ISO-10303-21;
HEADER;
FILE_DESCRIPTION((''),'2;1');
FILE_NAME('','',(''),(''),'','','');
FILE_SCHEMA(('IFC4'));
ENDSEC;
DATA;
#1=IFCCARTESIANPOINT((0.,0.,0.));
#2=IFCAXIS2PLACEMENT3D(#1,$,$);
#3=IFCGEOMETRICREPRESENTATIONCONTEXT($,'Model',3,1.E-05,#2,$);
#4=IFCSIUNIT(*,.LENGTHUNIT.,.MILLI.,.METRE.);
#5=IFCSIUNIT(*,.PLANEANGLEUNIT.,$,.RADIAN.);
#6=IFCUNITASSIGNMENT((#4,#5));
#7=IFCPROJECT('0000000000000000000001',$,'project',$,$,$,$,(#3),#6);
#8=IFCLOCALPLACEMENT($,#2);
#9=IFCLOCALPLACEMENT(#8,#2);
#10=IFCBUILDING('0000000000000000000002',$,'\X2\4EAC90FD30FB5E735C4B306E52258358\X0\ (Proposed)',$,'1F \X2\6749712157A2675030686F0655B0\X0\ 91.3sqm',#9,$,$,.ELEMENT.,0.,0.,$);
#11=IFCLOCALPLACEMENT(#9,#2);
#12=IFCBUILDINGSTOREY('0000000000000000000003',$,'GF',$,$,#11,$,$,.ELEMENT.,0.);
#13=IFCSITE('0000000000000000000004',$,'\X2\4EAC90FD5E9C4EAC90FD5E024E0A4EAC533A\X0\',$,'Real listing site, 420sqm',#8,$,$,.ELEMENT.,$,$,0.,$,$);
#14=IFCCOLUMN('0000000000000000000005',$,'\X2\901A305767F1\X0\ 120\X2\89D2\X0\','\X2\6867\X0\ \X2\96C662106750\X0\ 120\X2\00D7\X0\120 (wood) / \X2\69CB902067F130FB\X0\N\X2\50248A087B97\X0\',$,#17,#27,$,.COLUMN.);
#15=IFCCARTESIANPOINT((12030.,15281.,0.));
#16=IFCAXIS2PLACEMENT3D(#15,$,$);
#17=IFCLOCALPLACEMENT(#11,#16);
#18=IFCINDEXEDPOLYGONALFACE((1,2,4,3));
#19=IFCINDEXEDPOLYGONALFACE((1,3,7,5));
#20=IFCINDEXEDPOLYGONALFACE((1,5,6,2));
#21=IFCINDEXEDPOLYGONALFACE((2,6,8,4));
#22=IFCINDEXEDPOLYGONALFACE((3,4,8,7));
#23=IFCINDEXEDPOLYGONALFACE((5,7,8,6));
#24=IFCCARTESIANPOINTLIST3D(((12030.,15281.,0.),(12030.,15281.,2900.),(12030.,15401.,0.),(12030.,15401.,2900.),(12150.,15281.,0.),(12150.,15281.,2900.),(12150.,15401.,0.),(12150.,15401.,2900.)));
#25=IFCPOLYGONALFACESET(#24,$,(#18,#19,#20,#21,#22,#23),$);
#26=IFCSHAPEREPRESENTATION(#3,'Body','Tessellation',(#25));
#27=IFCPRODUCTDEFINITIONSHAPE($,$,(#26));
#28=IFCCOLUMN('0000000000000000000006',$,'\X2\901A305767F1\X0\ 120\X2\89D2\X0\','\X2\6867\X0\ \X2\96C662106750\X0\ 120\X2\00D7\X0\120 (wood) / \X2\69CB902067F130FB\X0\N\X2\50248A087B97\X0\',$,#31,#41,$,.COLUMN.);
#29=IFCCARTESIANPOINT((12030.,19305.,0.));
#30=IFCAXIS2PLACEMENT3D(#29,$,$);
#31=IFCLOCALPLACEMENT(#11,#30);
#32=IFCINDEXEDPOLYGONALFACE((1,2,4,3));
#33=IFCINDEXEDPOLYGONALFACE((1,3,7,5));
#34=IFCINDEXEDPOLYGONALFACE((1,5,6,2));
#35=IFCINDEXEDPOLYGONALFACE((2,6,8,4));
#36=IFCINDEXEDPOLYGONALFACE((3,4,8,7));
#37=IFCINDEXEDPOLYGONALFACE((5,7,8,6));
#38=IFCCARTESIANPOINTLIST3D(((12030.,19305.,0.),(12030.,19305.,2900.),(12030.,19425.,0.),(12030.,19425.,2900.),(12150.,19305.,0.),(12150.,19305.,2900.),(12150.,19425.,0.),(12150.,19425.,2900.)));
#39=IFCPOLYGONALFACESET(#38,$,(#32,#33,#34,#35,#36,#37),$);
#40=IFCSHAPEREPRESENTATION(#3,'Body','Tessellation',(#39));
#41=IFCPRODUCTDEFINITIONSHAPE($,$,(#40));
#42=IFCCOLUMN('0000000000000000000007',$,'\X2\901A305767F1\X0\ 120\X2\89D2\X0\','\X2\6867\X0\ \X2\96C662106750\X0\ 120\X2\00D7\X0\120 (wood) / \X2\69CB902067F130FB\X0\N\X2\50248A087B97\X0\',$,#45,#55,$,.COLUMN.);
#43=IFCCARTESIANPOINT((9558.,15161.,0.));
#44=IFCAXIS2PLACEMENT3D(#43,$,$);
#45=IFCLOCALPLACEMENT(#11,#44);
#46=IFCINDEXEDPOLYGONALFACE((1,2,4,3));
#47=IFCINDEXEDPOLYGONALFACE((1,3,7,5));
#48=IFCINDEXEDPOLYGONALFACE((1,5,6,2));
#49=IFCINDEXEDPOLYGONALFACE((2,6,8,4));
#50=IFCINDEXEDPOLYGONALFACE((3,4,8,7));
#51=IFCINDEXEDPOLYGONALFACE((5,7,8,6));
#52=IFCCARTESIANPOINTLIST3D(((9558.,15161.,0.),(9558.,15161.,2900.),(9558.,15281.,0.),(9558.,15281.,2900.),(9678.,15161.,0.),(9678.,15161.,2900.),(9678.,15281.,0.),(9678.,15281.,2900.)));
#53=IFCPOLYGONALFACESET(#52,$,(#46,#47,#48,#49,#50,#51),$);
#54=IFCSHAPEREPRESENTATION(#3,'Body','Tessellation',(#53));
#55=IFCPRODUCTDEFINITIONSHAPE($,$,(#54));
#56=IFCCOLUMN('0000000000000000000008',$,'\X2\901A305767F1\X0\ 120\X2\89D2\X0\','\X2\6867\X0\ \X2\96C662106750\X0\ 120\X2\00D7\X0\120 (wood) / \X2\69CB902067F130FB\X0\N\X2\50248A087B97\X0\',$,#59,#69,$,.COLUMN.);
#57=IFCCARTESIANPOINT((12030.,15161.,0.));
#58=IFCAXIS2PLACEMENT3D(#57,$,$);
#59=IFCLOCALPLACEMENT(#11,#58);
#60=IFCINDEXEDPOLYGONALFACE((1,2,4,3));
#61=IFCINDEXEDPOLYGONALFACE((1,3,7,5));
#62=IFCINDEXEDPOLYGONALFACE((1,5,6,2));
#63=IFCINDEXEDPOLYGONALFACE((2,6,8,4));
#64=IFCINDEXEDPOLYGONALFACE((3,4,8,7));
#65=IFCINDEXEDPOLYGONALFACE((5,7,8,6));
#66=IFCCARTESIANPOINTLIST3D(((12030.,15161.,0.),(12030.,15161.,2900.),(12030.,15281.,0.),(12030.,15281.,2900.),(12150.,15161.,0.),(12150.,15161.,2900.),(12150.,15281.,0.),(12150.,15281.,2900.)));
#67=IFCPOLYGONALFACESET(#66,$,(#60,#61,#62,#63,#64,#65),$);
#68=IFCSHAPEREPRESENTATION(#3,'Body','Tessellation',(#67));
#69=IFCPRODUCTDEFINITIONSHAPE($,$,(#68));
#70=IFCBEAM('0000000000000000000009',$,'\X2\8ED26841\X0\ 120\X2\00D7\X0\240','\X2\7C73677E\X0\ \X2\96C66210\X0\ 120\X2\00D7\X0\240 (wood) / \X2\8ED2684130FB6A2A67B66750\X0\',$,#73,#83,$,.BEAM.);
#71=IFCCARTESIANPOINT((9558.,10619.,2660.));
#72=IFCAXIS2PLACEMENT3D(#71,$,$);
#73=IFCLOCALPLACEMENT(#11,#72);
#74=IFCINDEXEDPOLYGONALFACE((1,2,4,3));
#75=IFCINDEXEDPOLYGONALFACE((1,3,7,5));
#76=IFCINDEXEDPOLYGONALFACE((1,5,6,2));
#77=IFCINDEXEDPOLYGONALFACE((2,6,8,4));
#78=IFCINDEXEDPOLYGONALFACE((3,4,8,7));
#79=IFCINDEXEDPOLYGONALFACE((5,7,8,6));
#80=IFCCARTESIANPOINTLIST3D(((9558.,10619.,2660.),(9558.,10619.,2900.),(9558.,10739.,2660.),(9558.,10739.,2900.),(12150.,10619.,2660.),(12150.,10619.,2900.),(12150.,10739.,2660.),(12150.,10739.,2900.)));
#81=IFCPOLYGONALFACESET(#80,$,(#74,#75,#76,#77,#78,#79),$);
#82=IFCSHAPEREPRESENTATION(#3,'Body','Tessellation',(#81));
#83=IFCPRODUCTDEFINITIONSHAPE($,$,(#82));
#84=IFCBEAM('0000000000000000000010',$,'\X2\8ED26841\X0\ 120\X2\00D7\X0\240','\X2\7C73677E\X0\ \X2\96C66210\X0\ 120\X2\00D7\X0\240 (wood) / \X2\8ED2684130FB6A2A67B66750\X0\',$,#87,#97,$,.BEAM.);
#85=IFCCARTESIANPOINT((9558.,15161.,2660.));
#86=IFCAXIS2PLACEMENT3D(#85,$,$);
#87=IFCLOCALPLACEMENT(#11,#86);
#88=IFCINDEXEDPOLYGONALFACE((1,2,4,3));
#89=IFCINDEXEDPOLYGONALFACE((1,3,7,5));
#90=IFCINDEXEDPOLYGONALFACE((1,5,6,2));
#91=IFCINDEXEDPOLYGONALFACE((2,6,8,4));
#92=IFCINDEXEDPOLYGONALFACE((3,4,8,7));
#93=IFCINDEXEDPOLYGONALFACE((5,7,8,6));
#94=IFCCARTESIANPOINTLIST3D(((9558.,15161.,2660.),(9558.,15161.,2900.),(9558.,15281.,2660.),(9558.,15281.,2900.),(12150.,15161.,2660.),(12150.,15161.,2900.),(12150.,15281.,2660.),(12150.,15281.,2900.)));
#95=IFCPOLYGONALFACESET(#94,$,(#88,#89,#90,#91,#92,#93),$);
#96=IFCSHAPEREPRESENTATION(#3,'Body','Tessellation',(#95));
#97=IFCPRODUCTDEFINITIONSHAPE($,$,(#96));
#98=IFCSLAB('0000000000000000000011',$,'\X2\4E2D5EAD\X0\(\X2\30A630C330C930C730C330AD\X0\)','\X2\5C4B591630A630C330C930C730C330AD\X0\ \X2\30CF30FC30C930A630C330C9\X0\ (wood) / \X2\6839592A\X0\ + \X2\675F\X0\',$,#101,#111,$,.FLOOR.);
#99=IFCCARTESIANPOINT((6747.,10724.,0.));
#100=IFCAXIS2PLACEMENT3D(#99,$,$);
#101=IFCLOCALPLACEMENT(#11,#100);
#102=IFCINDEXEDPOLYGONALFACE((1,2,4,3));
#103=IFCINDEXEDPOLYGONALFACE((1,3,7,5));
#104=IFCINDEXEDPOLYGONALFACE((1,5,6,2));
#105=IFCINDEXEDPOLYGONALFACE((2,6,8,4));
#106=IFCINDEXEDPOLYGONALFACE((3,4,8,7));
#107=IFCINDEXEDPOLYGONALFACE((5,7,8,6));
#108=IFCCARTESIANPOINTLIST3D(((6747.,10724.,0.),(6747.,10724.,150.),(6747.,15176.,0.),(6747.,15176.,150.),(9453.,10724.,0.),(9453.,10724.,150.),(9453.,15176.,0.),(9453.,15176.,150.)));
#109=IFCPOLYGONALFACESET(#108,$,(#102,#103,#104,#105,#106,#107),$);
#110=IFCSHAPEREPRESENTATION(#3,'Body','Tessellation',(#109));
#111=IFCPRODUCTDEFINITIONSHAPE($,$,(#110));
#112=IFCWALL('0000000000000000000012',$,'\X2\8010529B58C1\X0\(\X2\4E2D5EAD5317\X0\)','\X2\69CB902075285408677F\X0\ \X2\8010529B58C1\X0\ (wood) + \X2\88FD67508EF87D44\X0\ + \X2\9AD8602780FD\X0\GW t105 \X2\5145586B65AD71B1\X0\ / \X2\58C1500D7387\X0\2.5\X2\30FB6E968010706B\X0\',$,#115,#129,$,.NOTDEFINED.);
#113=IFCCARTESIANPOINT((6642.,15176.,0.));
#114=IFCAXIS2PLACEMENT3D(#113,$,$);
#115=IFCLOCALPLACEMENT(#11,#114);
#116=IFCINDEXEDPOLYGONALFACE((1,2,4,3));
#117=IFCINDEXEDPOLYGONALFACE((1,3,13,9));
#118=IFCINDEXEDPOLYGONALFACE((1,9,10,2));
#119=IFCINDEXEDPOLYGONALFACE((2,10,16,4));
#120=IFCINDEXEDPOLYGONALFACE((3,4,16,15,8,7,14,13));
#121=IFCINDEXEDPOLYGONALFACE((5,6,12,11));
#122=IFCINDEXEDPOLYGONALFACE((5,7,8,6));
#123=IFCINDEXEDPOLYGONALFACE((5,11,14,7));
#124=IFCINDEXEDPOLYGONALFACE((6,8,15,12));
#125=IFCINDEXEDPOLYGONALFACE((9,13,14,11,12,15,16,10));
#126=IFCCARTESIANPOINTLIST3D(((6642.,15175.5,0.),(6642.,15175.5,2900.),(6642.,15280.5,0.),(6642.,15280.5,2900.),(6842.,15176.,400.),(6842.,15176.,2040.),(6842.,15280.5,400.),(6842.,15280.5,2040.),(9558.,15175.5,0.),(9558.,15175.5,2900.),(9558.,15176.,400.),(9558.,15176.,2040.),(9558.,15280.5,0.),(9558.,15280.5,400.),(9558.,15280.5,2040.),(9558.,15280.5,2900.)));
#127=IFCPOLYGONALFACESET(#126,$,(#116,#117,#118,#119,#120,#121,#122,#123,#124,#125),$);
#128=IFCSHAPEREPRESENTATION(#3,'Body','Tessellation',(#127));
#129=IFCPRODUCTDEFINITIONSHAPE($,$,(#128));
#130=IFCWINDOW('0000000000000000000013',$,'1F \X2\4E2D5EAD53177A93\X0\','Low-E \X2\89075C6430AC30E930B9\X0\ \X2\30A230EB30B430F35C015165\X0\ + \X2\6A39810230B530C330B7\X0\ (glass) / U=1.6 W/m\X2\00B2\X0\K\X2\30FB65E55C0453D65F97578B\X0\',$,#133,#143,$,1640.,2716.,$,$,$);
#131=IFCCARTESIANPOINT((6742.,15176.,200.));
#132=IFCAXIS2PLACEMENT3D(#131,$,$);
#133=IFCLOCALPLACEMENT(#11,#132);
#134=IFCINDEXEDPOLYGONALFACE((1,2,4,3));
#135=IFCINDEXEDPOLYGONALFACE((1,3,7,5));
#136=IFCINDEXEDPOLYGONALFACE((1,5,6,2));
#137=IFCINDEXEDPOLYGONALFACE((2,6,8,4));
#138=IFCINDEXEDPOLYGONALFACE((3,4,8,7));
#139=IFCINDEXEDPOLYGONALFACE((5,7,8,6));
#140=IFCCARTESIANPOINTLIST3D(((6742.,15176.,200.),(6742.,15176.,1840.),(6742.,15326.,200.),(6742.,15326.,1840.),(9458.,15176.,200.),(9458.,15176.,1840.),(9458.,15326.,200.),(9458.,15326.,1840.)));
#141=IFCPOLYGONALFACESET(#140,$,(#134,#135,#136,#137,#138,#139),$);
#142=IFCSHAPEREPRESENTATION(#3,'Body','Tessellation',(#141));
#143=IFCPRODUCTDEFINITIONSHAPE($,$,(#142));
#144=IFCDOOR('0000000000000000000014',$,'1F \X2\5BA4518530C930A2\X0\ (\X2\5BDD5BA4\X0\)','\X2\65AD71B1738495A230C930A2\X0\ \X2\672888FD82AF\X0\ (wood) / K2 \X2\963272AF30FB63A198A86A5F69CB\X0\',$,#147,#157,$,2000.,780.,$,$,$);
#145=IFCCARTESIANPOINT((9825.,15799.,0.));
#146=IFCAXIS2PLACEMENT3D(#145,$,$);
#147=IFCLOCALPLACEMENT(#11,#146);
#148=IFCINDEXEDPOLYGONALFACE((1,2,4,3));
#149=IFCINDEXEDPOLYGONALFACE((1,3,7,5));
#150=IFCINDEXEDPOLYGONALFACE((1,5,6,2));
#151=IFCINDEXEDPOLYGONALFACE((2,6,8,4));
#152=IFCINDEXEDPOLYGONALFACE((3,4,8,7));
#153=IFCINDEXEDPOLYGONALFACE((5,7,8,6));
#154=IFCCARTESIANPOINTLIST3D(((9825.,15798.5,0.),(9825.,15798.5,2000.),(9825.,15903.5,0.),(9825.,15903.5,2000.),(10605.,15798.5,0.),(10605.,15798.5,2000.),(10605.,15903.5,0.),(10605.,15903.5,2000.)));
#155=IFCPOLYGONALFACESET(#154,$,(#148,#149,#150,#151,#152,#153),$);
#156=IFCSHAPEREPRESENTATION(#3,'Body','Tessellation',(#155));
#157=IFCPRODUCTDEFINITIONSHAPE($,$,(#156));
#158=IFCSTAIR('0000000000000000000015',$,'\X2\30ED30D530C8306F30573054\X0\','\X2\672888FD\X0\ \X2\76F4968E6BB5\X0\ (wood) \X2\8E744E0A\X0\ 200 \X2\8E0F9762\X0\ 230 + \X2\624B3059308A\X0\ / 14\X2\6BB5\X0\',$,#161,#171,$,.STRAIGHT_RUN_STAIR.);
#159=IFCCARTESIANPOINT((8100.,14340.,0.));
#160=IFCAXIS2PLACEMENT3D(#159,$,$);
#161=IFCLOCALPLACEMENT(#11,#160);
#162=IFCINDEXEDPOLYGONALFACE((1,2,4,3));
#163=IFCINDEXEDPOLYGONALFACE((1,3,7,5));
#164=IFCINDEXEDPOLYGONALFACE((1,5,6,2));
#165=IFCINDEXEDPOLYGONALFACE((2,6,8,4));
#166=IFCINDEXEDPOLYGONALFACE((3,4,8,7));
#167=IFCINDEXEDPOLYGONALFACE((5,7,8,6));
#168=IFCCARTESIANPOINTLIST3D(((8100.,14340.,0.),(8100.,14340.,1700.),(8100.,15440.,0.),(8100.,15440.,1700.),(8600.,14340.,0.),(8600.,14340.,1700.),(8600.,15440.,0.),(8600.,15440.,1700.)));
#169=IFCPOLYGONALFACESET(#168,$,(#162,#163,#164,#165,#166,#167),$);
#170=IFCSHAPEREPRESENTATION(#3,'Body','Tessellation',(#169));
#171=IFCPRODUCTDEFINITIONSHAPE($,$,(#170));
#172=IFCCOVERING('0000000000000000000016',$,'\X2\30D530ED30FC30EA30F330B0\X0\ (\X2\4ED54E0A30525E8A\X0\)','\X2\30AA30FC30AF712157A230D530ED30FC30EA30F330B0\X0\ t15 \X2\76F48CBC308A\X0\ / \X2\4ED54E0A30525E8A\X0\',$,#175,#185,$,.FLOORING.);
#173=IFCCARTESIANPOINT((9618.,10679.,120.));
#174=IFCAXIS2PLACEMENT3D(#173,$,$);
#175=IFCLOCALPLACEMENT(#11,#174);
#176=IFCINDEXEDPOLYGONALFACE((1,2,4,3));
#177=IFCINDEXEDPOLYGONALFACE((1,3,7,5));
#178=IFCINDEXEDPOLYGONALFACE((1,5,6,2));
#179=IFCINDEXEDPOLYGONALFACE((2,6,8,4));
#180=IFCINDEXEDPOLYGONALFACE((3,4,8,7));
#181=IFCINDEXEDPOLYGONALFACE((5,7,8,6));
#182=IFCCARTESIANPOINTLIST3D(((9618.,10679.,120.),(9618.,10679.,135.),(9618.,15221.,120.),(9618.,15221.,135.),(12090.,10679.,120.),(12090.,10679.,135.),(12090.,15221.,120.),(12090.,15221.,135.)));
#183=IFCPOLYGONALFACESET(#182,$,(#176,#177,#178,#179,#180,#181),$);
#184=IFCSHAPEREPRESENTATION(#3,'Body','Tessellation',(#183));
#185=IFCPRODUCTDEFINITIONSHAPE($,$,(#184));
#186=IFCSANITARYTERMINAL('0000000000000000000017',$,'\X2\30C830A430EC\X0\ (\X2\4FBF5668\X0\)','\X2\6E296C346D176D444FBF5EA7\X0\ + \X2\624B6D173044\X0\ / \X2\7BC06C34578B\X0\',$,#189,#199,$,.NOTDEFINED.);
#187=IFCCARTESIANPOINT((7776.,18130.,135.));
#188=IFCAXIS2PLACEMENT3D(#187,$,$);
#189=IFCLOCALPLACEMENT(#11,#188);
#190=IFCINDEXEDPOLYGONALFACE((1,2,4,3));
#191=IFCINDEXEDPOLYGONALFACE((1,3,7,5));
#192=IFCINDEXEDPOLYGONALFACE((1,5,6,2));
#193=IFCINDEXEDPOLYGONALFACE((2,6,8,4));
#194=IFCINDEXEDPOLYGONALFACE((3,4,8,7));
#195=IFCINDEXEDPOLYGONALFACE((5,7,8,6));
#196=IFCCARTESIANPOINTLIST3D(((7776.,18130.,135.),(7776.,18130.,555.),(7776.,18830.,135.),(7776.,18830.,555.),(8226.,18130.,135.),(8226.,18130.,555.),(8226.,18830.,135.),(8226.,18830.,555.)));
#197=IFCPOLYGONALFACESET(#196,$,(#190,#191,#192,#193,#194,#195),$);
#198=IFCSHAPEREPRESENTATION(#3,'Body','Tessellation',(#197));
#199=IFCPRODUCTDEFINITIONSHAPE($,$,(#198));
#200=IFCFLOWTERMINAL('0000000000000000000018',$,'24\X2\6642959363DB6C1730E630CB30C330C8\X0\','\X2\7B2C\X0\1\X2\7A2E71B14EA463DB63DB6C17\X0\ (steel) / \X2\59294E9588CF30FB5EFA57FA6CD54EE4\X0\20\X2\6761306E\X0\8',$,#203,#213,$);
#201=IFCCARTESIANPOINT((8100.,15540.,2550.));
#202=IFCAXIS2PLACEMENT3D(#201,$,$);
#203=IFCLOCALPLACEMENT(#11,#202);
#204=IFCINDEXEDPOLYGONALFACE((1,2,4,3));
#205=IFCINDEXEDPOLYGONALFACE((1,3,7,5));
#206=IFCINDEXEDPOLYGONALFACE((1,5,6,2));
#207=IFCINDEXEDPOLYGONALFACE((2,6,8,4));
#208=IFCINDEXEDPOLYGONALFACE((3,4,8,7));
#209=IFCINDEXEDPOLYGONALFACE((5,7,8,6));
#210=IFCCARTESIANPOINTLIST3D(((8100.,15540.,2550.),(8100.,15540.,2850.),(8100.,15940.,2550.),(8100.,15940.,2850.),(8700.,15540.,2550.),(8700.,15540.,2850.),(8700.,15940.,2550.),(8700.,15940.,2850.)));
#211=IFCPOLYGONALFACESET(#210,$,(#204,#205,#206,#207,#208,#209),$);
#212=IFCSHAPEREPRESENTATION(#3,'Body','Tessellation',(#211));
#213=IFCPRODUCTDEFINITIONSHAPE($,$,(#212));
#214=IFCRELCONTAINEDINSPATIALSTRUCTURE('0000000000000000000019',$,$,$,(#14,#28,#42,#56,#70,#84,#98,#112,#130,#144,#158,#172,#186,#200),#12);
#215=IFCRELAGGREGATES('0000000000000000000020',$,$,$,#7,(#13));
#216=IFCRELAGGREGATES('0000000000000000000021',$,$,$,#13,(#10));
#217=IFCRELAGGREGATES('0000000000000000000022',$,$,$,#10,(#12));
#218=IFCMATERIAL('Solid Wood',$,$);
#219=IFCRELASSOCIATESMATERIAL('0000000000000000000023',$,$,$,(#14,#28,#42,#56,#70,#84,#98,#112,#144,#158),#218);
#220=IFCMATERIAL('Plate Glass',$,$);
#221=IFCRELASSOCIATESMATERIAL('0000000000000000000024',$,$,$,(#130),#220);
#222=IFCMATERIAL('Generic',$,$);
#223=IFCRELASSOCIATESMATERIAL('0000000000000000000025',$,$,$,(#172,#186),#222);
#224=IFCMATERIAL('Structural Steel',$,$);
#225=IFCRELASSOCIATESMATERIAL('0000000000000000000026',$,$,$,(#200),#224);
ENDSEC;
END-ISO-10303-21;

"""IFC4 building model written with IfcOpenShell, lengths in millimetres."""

from ifc_helpers import new_model, si_unit, frame, frame_2d, origin, place, context, project, spatial, rectangle, extrude, material, element, fill, save


model = new_model("IFC4")

# Units and contexts
model_context = context("Model", 3, precision=1e-05, world=origin())
ifc_project = project(units=[si_unit("LENGTHUNIT", "METRE", prefix="MILLI"), si_unit("PLANEANGLEUNIT", "RADIAN")], contexts=[model_context])

# Site, building, storey
site_placement = place(None, origin())
site = spatial("IfcSite", under=ifc_project, at=site_placement, Name="京都府京都市上京区", ObjectType="Real listing site, 420sqm", CompositionType="ELEMENT", RefElevation=0.0)
building_placement = place(site_placement, origin())
building = spatial("IfcBuilding", under=site, at=building_placement, Name="京都・平屋の別荘 (Proposed)", ObjectType="1F 杉無垢材と漆喰 91.3sqm", CompositionType="ELEMENT", ElevationOfRefHeight=0.0, ElevationOfTerrain=0.0)
storey_placement = place(building_placement, origin())
storey = spatial("IfcBuildingStorey", under=building, at=storey_placement, Name="GF", CompositionType="ELEMENT", Elevation=0.0)

# Columns
ifc_material_1 = material(Name="Solid Wood")
column_1_placement = place(storey_placement, frame((12030.0, 15281.0, 0.0)))
element("IfcColumn", 1, at=column_1_placement, inside=storey, material=ifc_material_1, Name="通し柱 120角", Description="桧 集成材 120×120 (wood) / 構造柱・N値計算", PredefinedType="COLUMN", context=model_context, shape_type="SweptSolid", body=[
    extrude(rectangle(XDim=120.0, YDim=120.0, at=frame_2d((60.0, 60.0))), frame((12030.0, 15281.0, 0.0)), (0.0, 0.0, 1.0), 2900.0),
])
column_2_placement = place(storey_placement, frame((12030.0, 19305.0, 0.0)))
element("IfcColumn", 2, at=column_2_placement, inside=storey, material=ifc_material_1, Name="通し柱 120角", Description="桧 集成材 120×120 (wood) / 構造柱・N値計算", PredefinedType="COLUMN", context=model_context, shape_type="SweptSolid", body=[
    extrude(rectangle(XDim=120.0, YDim=120.0, at=frame_2d((60.0, 60.0))), frame((12030.0, 19305.0, 0.0)), (0.0, 0.0, 1.0), 2900.0),
])
column_3_placement = place(storey_placement, frame((9558.0, 15161.0, 0.0)))
element("IfcColumn", 3, at=column_3_placement, inside=storey, material=ifc_material_1, Name="通し柱 120角", Description="桧 集成材 120×120 (wood) / 構造柱・N値計算", PredefinedType="COLUMN", context=model_context, shape_type="SweptSolid", body=[
    extrude(rectangle(XDim=120.0, YDim=120.0, at=frame_2d((60.0, 60.0))), frame((9558.0, 15161.0, 0.0)), (0.0, 0.0, 1.0), 2900.0),
])
column_4_placement = place(storey_placement, frame((12030.0, 15161.0, 0.0)))
element("IfcColumn", 4, at=column_4_placement, inside=storey, material=ifc_material_1, Name="通し柱 120角", Description="桧 集成材 120×120 (wood) / 構造柱・N値計算", PredefinedType="COLUMN", context=model_context, shape_type="SweptSolid", body=[
    extrude(rectangle(XDim=120.0, YDim=120.0, at=frame_2d((60.0, 60.0))), frame((12030.0, 15161.0, 0.0)), (0.0, 0.0, 1.0), 2900.0),
])

# Beams
beam_1_placement = place(storey_placement, frame((9558.0, 10619.0, 2660.0)))
element("IfcBeam", 5, at=beam_1_placement, inside=storey, material=ifc_material_1, Name="軒桁 120×240", Description="米松 集成 120×240 (wood) / 軒桁・横架材", PredefinedType="BEAM", context=model_context, shape_type="SweptSolid", body=[
    extrude(rectangle(XDim=2592.0, YDim=120.0, at=frame_2d((1296.0, 60.0))), frame((9558.0, 10619.0, 2660.0)), (0.0, 0.0, 1.0), 240.0),
])
beam_2_placement = place(storey_placement, frame((9558.0, 15161.0, 2660.0)))
element("IfcBeam", 6, at=beam_2_placement, inside=storey, material=ifc_material_1, Name="軒桁 120×240", Description="米松 集成 120×240 (wood) / 軒桁・横架材", PredefinedType="BEAM", context=model_context, shape_type="SweptSolid", body=[
    extrude(rectangle(XDim=2592.0, YDim=120.0, at=frame_2d((1296.0, 60.0))), frame((9558.0, 15161.0, 2660.0)), (0.0, 0.0, 1.0), 240.0),
])

# Slab
slab_placement = place(storey_placement, frame((6747.0, 10724.0, 0.0)))
element("IfcSlab", 7, at=slab_placement, inside=storey, material=ifc_material_1, Name="中庭(ウッドデッキ)", Description="屋外ウッドデッキ ハードウッド (wood) / 根太 + 束", PredefinedType="FLOOR", context=model_context, shape_type="SweptSolid", body=[
    extrude(rectangle(XDim=2706.0, YDim=4452.0, at=frame_2d((1353.0, 2226.0))), frame((6747.0, 10724.0, 0.0)), (0.0, 0.0, 1.0), 150.0),
])

# Wall, opening, window
wall_1_placement = place(storey_placement, frame((6642.0, 15176.0, 0.0)))
wall_1 = element("IfcWall", 8, at=wall_1_placement, inside=storey, material=ifc_material_1, Name="耐力壁(中庭北)", Description="構造用合板 耐力壁 (wood) + 製材軸組 + 高性能GW t105 充填断熱 / 壁倍率2.5・準耐火", PredefinedType="NOTDEFINED", context=model_context, shape_type="SweptSolid", body=[
    extrude(rectangle(XDim=2916.0, YDim=105.0, at=frame_2d((1458.0, 52.0))), frame((6642.0, 15176.0, 0.0)), (0.0, 0.0, 1.0), 2900.0),
])
opening_placement = place(storey_placement, frame((6742.0, 15176.0, 200.0)))
opening = element("IfcOpeningElement", 9, at=opening_placement, cuts=wall_1, PredefinedType="NOTDEFINED", context=model_context, shape_type="SweptSolid", body=[
    extrude(rectangle(XDim=2716.0, YDim=150.0, at=frame_2d((1358.0, 75.0))), frame((6742.0, 15176.0, 200.0)), (0.0, 0.0, 1.0), 1640.0),
])
ifc_material_2 = material(Name="Plate Glass")
window_placement = place(storey_placement, frame((6742.0, 15176.0, 200.0)))
window = element("IfcWindow", 10, at=window_placement, inside=storey, material=ifc_material_2, Name="1F 中庭北窓", Description="Low-E 複層ガラス アルゴン封入 + 樹脂サッシ (glass) / U=1.6 W/m²K・日射取得型", OverallHeight=1640.0, OverallWidth=2716.0, context=model_context, shape_type="SweptSolid", body=[
    extrude(rectangle(XDim=2716.0, YDim=150.0, at=frame_2d((1358.0, 75.0))), frame((6742.0, 15176.0, 200.0)), (0.0, 0.0, 1.0), 1640.0),
])
fill(opening, window)

# Door
door_placement = place(storey_placement, frame((9825.0, 15799.0, 0.0)))
element("IfcDoor", 11, at=door_placement, inside=storey, material=ifc_material_1, Name="1F 室内ドア (寝室)", Description="断熱玄関ドア 木製芯 (wood) / K2 防犯・採風機構", OverallHeight=2000.0, OverallWidth=780.0, context=model_context, shape_type="SweptSolid", body=[
    extrude(rectangle(XDim=780.0, YDim=105.0, at=frame_2d((390.0, 52.0))), frame((9825.0, 15799.0, 0.0)), (0.0, 0.0, 1.0), 2000.0),
])

# Stair
stair_placement = place(storey_placement, frame((8100.0, 14340.0, 0.0)))
element("IfcStair", 12, at=stair_placement, inside=storey, material=ifc_material_1, Name="ロフトはしご", Description="木製 直階段 (wood) 蹴上 200 踏面 230 + 手すり / 14段", PredefinedType="STRAIGHT_RUN_STAIR", context=model_context, shape_type="SweptSolid", body=[
    extrude(rectangle(XDim=500.0, YDim=1100.0, at=frame_2d((250.0, 550.0))), frame((8100.0, 14340.0, 0.0)), (0.0, 0.0, 1.0), 1700.0),
])

# Covering
ifc_material_3 = material(Name="Generic")
covering_placement = place(storey_placement, frame((9618.0, 10679.0, 120.0)))
element("IfcCovering", 13, at=covering_placement, inside=storey, material=ifc_material_3, Name="フローリング (仕上げ床)", Description="オーク無垢フローリング t15 直貼り / 仕上げ床", PredefinedType="FLOORING", context=model_context, shape_type="SweptSolid", body=[
    extrude(rectangle(XDim=2472.0, YDim=4542.0, at=frame_2d((1236.0, 2271.0))), frame((9618.0, 10679.0, 120.0)), (0.0, 0.0, 1.0), 15.0),
])

# Sanitary terminal
sanitary_terminal_placement = place(storey_placement, frame((7776.0, 18130.0, 135.0)))
element("IfcSanitaryTerminal", 14, at=sanitary_terminal_placement, inside=storey, material=ifc_material_3, Name="トイレ (便器)", Description="温水洗浄便座 + 手洗い / 節水型", PredefinedType="NOTDEFINED", context=model_context, shape_type="SweptSolid", body=[
    extrude(rectangle(XDim=450.0, YDim=700.0, at=frame_2d((225.0, 350.0))), frame((7776.0, 18130.0, 135.0)), (0.0, 0.0, 1.0), 420.0),
])

# Flow terminal
ifc_material_4 = material(Name="Structural Steel")
flow_terminal_placement = place(storey_placement, frame((8100.0, 15540.0, 2550.0)))
element("IfcFlowTerminal", 15, at=flow_terminal_placement, inside=storey, material=ifc_material_4, Name="24時間換気ユニット", Description="第1種熱交換換気 (steel) / 天井裏・建基法令20条の8", context=model_context, shape_type="SweptSolid", body=[
    extrude(rectangle(XDim=600.0, YDim=400.0, at=frame_2d((300.0, 200.0))), frame((8100.0, 15540.0, 2550.0)), (0.0, 0.0, 1.0), 300.0),
])

save(model, "model.ifc")
